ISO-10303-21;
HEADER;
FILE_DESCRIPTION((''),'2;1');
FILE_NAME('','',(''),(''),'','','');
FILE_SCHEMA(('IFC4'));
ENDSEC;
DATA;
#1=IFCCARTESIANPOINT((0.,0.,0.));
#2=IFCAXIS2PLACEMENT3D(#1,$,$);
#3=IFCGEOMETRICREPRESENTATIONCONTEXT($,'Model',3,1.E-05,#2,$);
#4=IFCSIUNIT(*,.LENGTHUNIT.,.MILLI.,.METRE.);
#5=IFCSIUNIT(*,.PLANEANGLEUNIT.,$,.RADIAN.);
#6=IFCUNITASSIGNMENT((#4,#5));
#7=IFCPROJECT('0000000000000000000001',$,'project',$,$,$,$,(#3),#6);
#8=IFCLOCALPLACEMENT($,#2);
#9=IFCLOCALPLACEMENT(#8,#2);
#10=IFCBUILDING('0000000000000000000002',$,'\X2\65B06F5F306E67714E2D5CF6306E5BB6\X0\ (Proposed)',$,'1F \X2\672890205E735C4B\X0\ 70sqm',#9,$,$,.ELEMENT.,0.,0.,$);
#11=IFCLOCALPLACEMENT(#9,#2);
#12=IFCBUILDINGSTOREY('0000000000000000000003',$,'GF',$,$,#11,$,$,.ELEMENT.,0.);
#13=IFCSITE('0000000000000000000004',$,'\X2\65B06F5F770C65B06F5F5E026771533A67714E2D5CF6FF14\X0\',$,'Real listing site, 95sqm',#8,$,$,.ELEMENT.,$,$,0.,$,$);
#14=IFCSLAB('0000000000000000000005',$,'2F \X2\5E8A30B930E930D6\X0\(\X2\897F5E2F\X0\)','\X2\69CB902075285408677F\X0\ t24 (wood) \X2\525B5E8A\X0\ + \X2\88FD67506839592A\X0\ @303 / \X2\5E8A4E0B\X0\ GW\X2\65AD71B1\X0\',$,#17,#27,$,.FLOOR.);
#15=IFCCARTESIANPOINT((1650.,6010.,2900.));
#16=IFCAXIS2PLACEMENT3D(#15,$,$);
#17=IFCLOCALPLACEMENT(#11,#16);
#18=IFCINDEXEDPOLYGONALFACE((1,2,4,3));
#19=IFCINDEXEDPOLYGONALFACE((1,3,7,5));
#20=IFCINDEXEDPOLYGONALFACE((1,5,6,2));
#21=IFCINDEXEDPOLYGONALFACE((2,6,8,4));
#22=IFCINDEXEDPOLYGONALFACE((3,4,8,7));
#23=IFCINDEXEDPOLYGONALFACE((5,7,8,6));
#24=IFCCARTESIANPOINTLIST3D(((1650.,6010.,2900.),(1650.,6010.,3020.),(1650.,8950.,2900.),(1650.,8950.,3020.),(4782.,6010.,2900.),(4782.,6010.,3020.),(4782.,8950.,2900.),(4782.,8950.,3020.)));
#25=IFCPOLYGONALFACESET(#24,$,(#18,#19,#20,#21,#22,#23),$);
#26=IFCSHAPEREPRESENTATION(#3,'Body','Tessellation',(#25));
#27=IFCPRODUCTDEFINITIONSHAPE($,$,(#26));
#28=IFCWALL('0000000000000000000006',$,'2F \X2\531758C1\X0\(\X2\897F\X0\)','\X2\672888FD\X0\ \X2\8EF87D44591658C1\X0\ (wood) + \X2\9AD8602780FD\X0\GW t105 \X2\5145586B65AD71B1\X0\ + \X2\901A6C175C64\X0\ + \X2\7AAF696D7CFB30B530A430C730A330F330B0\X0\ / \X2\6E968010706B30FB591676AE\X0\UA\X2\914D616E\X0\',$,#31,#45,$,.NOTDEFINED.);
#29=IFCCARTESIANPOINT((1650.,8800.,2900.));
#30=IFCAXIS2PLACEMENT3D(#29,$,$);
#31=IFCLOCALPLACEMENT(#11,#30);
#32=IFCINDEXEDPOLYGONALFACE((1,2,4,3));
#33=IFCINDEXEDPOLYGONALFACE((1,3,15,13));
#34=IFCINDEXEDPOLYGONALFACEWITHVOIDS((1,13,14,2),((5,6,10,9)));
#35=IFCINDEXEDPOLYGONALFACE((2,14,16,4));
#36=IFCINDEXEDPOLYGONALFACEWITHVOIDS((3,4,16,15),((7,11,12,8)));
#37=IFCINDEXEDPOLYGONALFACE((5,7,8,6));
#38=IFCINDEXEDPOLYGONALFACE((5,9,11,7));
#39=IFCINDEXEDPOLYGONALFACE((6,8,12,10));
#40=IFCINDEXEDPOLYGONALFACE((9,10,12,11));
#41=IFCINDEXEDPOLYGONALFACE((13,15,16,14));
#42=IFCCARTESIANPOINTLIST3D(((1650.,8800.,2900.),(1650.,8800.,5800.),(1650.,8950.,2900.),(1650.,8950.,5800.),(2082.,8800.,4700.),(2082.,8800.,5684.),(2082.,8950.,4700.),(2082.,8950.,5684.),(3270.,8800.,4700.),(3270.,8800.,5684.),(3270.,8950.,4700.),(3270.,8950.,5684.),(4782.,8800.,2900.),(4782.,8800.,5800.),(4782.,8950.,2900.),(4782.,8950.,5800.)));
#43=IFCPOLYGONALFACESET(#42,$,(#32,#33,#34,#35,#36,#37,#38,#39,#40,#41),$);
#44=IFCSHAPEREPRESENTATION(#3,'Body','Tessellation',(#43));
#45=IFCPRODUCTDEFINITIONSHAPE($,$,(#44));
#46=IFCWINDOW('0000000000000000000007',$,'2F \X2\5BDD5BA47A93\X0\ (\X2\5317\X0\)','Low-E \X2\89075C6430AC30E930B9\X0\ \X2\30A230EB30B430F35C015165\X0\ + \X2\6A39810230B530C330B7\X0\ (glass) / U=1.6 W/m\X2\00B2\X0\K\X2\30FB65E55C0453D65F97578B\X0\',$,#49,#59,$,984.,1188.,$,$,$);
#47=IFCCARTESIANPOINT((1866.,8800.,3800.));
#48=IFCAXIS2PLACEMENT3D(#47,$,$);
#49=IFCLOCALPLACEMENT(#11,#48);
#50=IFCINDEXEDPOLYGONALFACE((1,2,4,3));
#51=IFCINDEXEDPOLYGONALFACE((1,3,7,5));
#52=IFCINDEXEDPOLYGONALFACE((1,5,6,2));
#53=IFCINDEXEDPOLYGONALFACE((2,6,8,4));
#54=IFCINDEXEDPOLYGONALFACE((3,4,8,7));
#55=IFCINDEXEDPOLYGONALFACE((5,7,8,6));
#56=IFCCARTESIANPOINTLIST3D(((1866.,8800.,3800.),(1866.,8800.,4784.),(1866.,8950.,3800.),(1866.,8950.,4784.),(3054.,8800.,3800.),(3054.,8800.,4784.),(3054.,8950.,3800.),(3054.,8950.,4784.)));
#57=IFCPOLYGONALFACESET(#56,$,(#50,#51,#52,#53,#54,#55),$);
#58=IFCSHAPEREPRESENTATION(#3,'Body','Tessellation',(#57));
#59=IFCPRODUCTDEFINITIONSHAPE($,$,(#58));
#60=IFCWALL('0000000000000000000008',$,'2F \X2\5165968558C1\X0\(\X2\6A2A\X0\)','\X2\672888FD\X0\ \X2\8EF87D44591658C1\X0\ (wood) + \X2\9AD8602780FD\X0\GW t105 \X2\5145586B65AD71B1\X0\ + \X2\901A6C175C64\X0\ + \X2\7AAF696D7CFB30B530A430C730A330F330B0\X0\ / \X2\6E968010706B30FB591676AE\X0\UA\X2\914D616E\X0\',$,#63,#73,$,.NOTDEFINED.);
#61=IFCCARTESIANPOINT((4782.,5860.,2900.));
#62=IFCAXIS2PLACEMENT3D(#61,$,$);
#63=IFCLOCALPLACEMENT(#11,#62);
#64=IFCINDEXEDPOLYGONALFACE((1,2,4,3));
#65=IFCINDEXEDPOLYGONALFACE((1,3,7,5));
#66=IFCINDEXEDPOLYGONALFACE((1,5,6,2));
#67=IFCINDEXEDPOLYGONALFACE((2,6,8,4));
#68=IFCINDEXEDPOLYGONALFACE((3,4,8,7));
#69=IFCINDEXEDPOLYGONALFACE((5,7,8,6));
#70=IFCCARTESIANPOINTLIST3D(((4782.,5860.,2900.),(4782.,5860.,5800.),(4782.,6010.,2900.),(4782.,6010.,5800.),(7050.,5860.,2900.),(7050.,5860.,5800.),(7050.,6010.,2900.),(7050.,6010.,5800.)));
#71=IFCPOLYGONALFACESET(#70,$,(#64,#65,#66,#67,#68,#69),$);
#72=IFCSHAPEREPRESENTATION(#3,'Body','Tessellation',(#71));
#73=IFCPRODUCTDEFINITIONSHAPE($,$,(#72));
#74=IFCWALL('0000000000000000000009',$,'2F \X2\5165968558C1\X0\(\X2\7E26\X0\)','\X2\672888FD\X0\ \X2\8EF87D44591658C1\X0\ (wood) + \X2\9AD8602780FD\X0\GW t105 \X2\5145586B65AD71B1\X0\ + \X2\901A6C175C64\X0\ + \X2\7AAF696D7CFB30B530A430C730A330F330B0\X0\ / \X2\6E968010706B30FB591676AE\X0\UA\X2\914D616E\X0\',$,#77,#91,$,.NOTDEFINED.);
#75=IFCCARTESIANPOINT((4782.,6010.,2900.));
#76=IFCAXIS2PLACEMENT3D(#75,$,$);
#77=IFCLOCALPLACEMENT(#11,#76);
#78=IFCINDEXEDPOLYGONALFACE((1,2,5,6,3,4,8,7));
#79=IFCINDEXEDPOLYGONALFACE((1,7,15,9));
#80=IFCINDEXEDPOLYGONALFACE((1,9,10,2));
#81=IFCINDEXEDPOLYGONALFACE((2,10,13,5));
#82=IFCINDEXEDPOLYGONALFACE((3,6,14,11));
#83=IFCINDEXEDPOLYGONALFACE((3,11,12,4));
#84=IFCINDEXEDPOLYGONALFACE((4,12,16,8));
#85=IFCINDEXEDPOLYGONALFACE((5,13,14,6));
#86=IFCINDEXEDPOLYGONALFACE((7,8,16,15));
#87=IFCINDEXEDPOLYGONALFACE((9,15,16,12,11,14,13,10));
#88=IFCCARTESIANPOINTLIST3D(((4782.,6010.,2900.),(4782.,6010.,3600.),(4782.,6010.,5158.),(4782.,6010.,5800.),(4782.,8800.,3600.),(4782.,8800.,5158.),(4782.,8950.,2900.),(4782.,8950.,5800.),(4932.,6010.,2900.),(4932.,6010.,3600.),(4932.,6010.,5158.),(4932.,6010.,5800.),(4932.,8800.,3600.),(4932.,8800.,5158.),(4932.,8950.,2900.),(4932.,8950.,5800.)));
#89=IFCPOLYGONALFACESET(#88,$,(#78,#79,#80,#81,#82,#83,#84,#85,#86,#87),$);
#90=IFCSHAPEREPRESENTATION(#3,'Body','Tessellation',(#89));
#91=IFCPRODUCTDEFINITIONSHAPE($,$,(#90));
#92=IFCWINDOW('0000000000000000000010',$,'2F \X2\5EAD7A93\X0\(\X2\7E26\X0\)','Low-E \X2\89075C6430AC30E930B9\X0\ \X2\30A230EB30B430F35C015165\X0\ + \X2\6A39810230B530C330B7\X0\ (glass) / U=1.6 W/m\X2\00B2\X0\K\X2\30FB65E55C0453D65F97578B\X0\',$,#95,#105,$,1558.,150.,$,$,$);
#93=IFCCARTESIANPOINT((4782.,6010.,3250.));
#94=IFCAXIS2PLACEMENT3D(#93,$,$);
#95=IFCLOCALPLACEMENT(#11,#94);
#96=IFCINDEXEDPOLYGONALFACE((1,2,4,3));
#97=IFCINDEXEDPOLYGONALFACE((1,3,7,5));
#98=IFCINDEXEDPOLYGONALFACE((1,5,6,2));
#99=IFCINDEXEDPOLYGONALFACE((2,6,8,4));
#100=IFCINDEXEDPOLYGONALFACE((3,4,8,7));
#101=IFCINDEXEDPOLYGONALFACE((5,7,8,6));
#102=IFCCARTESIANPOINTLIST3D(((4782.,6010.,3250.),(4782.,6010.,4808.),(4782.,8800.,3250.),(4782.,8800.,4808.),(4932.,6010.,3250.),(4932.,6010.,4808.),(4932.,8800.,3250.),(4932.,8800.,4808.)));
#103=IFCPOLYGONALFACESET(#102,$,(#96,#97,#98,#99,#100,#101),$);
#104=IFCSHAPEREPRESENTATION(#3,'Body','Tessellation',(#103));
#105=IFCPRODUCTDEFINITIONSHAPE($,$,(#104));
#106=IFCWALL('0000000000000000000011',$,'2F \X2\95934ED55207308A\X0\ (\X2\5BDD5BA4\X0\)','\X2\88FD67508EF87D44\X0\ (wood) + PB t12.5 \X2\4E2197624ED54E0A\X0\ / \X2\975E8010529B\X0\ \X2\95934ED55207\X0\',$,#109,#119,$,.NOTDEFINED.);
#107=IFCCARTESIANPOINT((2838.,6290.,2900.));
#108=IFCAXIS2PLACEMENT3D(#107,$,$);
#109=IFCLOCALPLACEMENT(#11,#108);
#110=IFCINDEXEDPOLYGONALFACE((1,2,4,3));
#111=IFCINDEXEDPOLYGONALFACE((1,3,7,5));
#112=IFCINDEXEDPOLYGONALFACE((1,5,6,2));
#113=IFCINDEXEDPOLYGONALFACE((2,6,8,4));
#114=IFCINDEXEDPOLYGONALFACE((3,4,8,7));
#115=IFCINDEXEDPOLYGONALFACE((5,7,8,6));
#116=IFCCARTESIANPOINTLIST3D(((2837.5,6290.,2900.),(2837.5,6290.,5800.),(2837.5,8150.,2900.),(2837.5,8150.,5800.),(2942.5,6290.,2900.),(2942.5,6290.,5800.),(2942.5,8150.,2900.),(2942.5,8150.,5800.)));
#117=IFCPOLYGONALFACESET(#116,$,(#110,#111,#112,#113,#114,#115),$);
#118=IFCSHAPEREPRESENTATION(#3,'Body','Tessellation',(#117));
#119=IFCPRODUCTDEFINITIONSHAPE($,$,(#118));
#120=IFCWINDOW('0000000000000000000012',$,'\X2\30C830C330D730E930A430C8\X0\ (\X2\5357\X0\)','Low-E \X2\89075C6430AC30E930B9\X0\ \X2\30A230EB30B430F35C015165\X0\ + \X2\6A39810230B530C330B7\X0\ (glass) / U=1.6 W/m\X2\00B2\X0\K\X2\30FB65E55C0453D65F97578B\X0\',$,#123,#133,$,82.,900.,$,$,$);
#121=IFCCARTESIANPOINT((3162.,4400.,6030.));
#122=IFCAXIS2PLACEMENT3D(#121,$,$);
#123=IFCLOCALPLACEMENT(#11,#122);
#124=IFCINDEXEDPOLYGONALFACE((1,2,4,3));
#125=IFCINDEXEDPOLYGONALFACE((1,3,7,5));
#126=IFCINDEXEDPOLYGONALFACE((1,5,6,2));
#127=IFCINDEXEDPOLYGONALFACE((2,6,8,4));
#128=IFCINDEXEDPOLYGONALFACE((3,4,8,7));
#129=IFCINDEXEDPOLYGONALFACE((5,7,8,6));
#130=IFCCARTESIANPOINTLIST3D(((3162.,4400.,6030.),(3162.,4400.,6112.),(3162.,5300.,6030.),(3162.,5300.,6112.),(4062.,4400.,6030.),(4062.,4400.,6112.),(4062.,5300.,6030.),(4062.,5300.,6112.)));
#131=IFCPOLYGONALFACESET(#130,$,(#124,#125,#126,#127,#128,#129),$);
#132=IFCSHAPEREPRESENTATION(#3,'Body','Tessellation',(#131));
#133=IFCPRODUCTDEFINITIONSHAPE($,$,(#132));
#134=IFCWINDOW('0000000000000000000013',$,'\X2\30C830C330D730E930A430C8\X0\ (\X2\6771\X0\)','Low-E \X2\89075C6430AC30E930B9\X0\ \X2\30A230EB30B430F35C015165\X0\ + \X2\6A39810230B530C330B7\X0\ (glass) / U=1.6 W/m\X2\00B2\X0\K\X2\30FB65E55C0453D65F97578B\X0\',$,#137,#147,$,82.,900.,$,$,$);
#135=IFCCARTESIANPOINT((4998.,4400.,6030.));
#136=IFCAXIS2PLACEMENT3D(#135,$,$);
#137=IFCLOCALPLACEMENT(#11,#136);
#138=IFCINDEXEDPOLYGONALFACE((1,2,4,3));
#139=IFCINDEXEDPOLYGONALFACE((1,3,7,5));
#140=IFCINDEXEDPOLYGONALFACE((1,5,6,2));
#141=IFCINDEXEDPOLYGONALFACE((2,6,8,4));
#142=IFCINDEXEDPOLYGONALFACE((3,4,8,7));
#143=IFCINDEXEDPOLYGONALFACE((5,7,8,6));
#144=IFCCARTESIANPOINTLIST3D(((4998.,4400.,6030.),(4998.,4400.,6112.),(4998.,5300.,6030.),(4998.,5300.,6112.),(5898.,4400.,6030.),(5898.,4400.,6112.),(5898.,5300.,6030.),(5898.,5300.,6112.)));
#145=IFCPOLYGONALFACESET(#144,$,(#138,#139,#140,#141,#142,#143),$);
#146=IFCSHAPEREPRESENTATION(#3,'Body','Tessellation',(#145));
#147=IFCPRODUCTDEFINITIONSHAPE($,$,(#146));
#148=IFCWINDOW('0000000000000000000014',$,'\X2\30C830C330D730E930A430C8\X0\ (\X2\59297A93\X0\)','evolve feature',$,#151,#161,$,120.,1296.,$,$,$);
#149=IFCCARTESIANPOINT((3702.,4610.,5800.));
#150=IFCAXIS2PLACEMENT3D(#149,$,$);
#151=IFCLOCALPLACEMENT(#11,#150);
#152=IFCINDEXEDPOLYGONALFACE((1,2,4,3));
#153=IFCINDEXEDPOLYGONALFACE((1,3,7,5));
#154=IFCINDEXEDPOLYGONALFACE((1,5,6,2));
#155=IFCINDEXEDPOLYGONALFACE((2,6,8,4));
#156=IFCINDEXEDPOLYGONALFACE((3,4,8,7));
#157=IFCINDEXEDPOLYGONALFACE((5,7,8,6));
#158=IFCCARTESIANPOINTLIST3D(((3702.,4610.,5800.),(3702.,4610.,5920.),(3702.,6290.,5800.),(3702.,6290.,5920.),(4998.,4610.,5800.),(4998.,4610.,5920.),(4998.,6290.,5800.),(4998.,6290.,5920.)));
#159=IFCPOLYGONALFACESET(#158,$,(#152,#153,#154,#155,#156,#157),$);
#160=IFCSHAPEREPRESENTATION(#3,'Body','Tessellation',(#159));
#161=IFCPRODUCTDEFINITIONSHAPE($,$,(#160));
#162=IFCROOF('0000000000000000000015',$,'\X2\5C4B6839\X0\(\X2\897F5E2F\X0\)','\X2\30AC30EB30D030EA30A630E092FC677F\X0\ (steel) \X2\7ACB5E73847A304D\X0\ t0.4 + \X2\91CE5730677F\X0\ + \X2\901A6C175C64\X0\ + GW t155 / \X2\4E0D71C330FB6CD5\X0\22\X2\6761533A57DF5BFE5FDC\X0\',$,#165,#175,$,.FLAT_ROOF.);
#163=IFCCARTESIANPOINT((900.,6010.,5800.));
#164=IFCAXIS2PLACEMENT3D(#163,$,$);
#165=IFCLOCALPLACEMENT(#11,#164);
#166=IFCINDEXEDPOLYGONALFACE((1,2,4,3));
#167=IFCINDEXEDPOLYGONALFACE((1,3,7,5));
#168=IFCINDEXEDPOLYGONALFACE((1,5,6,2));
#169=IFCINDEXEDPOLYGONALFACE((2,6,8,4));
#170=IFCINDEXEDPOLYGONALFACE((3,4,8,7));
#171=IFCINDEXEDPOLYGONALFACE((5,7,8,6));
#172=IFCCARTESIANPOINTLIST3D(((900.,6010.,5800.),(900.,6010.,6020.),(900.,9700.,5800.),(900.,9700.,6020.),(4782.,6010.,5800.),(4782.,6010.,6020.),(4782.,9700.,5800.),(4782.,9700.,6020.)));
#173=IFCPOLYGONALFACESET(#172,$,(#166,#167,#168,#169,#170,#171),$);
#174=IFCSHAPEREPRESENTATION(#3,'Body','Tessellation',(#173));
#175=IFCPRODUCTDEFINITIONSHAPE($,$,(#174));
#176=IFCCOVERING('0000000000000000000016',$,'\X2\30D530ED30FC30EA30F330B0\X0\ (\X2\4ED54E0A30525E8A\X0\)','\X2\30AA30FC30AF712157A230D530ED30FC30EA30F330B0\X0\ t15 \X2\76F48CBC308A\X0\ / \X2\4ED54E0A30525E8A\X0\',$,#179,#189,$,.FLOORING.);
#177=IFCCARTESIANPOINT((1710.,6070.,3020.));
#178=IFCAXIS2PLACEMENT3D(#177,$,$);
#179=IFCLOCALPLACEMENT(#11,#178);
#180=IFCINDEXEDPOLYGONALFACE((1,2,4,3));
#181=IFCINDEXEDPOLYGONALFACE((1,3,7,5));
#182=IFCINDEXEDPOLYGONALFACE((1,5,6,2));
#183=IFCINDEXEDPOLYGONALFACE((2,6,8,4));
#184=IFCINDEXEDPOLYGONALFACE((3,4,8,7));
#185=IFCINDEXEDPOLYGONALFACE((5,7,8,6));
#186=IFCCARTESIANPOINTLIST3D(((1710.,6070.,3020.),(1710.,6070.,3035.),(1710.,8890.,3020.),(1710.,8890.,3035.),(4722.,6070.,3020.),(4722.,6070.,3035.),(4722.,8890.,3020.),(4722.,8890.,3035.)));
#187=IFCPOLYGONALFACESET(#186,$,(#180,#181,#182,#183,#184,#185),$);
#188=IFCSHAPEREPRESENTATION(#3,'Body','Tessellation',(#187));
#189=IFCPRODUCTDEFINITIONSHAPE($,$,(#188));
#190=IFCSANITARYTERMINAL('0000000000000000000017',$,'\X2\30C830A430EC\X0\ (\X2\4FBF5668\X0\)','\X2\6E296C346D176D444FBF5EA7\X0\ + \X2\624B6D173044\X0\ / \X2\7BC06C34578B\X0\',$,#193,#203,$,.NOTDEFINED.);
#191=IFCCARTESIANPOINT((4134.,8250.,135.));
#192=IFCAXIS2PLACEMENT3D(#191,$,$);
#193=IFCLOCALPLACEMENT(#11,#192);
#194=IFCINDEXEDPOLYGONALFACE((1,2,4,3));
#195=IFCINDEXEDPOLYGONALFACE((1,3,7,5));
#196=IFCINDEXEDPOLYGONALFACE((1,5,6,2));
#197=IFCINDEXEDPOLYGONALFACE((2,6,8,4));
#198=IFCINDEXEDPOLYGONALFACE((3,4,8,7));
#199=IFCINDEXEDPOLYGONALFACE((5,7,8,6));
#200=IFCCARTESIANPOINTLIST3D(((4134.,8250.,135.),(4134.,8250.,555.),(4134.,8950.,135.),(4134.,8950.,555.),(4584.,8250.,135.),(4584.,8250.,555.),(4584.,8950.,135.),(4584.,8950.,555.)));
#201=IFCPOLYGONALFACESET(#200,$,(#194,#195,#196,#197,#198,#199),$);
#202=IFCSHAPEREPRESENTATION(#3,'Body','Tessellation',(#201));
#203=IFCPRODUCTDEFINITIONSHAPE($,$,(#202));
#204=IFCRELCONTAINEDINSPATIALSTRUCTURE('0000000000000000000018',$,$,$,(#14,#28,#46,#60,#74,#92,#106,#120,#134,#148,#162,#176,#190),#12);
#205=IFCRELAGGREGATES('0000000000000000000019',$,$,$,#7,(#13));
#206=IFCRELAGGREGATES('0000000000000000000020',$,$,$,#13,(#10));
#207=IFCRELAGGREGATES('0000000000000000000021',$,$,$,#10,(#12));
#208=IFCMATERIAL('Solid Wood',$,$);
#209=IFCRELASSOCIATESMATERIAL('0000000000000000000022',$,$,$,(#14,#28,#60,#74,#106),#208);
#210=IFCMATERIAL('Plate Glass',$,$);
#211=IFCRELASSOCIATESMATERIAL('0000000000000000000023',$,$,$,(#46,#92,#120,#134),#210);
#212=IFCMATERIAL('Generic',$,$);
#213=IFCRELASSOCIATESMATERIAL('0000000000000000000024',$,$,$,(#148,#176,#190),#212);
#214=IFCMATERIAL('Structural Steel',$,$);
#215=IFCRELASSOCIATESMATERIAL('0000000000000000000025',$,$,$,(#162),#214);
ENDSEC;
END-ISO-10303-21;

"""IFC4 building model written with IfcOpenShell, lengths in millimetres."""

from ifc_helpers import new_model, si_unit, frame, frame_2d, origin, place, context, project, spatial, rectangle, extrude, material, element, fill, save


model = new_model("IFC4")

# Units and contexts
model_context = context("Model", 3, precision=1e-05, world=origin())
ifc_project = project(units=[si_unit("LENGTHUNIT", "METRE", prefix="MILLI"), si_unit("PLANEANGLEUNIT", "RADIAN")], contexts=[model_context])

# Site, building, storey
site_placement = place(None, origin())
site = spatial("IfcSite", under=ifc_project, at=site_placement, Name="新潟県新潟市東区東中島４", ObjectType="Real listing site, 95sqm", CompositionType="ELEMENT", RefElevation=0.0)
building_placement = place(site_placement, origin())
building = spatial("IfcBuilding", under=site, at=building_placement, Name="新潟の東中島の家 (Proposed)", ObjectType="1F 木造平屋 70sqm", CompositionType="ELEMENT", ElevationOfRefHeight=0.0, ElevationOfTerrain=0.0)
storey_placement = place(building_placement, origin())
storey = spatial("IfcBuildingStorey", under=building, at=storey_placement, Name="GF", CompositionType="ELEMENT", Elevation=0.0)

# Slab
ifc_material_1 = material(Name="Solid Wood")
slab_placement = place(storey_placement, frame((1650.0, 6010.0, 2900.0)))
element("IfcSlab", 1, at=slab_placement, inside=storey, material=ifc_material_1, Name="2F 床スラブ(西帯)", Description="構造用合板 t24 (wood) 剛床 + 製材根太 @303 / 床下 GW断熱", PredefinedType="FLOOR", context=model_context, shape_type="SweptSolid", body=[
    extrude(rectangle(XDim=3132.0, YDim=2940.0, at=frame_2d((1566.0, 1470.0))), frame((1650.0, 6010.0, 2900.0)), (0.0, 0.0, 1.0), 120.0),
])

# Wall, opening, window
wall_1_placement = place(storey_placement, frame((1650.0, 8800.0, 2900.0)))
wall_1 = element("IfcWall", 2, at=wall_1_placement, inside=storey, material=ifc_material_1, Name="2F 北壁(西)", Description="木製 軸組外壁 (wood) + 高性能GW t105 充填断熱 + 通気層 + 窯業系サイディング / 準耐火・外皮UA配慮", PredefinedType="NOTDEFINED", context=model_context, shape_type="SweptSolid", body=[
    extrude(rectangle(XDim=3132.0, YDim=150.0, at=frame_2d((1566.0, 75.0))), frame((1650.0, 8800.0, 2900.0)), (0.0, 0.0, 1.0), 2900.0),
])
opening_1_placement = place(storey_placement, frame((1866.0, 8800.0, 3800.0)))
opening_1 = element("IfcOpeningElement", 3, at=opening_1_placement, cuts=wall_1, PredefinedType="NOTDEFINED", context=model_context, shape_type="SweptSolid", body=[
    extrude(rectangle(XDim=1188.0, YDim=150.0, at=frame_2d((594.0, 75.0))), frame((1866.0, 8800.0, 3800.0)), (0.0, 0.0, 1.0), 984.0),
])
ifc_material_2 = material(Name="Plate Glass")
window_1_placement = place(storey_placement, frame((1866.0, 8800.0, 3800.0)))
window_1 = element("IfcWindow", 4, at=window_1_placement, inside=storey, material=ifc_material_2, Name="2F 寝室窓 (北)", Description="Low-E 複層ガラス アルゴン封入 + 樹脂サッシ (glass) / U=1.6 W/m²K・日射取得型", OverallHeight=984.0, OverallWidth=1188.0, context=model_context, shape_type="SweptSolid", body=[
    extrude(rectangle(XDim=1188.0, YDim=150.0, at=frame_2d((594.0, 75.0))), frame((1866.0, 8800.0, 3800.0)), (0.0, 0.0, 1.0), 984.0),
])
fill(opening_1, window_1)

# Wall
wall_2_placement = place(storey_placement, frame((4782.0, 5860.0, 2900.0)))
element("IfcWall", 5, at=wall_2_placement, inside=storey, material=ifc_material_1, Name="2F 入隅壁(横)", Description="木製 軸組外壁 (wood) + 高性能GW t105 充填断熱 + 通気層 + 窯業系サイディング / 準耐火・外皮UA配慮", PredefinedType="NOTDEFINED", context=model_context, shape_type="SweptSolid", body=[
    extrude(rectangle(XDim=2268.0, YDim=150.0, at=frame_2d((1134.0, 75.0))), frame((4782.0, 5860.0, 2900.0)), (0.0, 0.0, 1.0), 2900.0),
])

# Wall, opening, window
wall_3_placement = place(storey_placement, frame((4782.0, 6010.0, 2900.0)))
wall_3 = element("IfcWall", 6, at=wall_3_placement, inside=storey, material=ifc_material_1, Name="2F 入隅壁(縦)", Description="木製 軸組外壁 (wood) + 高性能GW t105 充填断熱 + 通気層 + 窯業系サイディング / 準耐火・外皮UA配慮", PredefinedType="NOTDEFINED", context=model_context, shape_type="SweptSolid", body=[
    extrude(rectangle(XDim=150.0, YDim=2940.0, at=frame_2d((75.0, 1470.0))), frame((4782.0, 6010.0, 2900.0)), (0.0, 0.0, 1.0), 2900.0),
])
opening_2_placement = place(storey_placement, frame((4782.0, 6010.0, 3250.0)))
opening_2 = element("IfcOpeningElement", 7, at=opening_2_placement, cuts=wall_3, PredefinedType="NOTDEFINED", context=model_context, shape_type="SweptSolid", body=[
    extrude(rectangle(XDim=150.0, YDim=2790.0, at=frame_2d((75.0, 1395.0))), frame((4782.0, 6010.0, 3250.0)), (0.0, 0.0, 1.0), 1558.0),
])
window_2_placement = place(storey_placement, frame((4782.0, 6010.0, 3250.0)))
window_2 = element("IfcWindow", 8, at=window_2_placement, inside=storey, material=ifc_material_2, Name="2F 庭窓(縦)", Description="Low-E 複層ガラス アルゴン封入 + 樹脂サッシ (glass) / U=1.6 W/m²K・日射取得型", OverallHeight=1558.0, OverallWidth=150.0, context=model_context, shape_type="SweptSolid", body=[
    extrude(rectangle(XDim=150.0, YDim=2790.0, at=frame_2d((75.0, 1395.0))), frame((4782.0, 6010.0, 3250.0)), (0.0, 0.0, 1.0), 1558.0),
])
fill(opening_2, window_2)

# Wall
wall_4_placement = place(storey_placement, frame((2838.0, 6290.0, 2900.0)))
element("IfcWall", 9, at=wall_4_placement, inside=storey, material=ifc_material_1, Name="2F 間仕切り (寝室)", Description="製材軸組 (wood) + PB t12.5 両面仕上 / 非耐力 間仕切", PredefinedType="NOTDEFINED", context=model_context, shape_type="SweptSolid", body=[
    extrude(rectangle(XDim=105.0, YDim=1860.0, at=frame_2d((52.0, 930.0))), frame((2838.0, 6290.0, 2900.0)), (0.0, 0.0, 1.0), 2900.0),
])

# Windows
window_3_placement = place(storey_placement, frame((3162.0, 4400.0, 6030.0)))
element("IfcWindow", 10, at=window_3_placement, inside=storey, material=ifc_material_2, Name="トップライト (南)", Description="Low-E 複層ガラス アルゴン封入 + 樹脂サッシ (glass) / U=1.6 W/m²K・日射取得型", OverallHeight=82.0, OverallWidth=900.0, context=model_context, shape_type="SweptSolid", body=[
    extrude(rectangle(XDim=900.0, YDim=900.0, at=frame_2d((450.0, 450.0))), frame((3162.0, 4400.0, 6030.0)), (0.0, 0.0, 1.0), 82.0),
])
window_4_placement = place(storey_placement, frame((4998.0, 4400.0, 6030.0)))
element("IfcWindow", 11, at=window_4_placement, inside=storey, material=ifc_material_2, Name="トップライト (東)", Description="Low-E 複層ガラス アルゴン封入 + 樹脂サッシ (glass) / U=1.6 W/m²K・日射取得型", OverallHeight=82.0, OverallWidth=900.0, context=model_context, shape_type="SweptSolid", body=[
    extrude(rectangle(XDim=900.0, YDim=900.0, at=frame_2d((450.0, 450.0))), frame((4998.0, 4400.0, 6030.0)), (0.0, 0.0, 1.0), 82.0),
])
ifc_material_3 = material(Name="Generic")
window_5_placement = place(storey_placement, frame((3702.0, 4610.0, 5800.0)))
element("IfcWindow", 12, at=window_5_placement, inside=storey, material=ifc_material_3, Name="トップライト (天窓)", Description="evolve feature", OverallHeight=120.0, OverallWidth=1296.0, context=model_context, shape_type="SweptSolid", body=[
    extrude(rectangle(XDim=1296.0, YDim=1680.0, at=frame_2d((648.0, 840.0))), frame((3702.0, 4610.0, 5800.0)), (0.0, 0.0, 1.0), 120.0),
])

# Roof
ifc_material_4 = material(Name="Structural Steel")
for number, where, name in (
    (13, (900.0, 6010.0, 5800.0), "屋根(西帯)"),
):
    element("IfcRoof", number, at=place(storey_placement, frame(where)), inside=storey, material=ifc_material_4, Name=name, Description="ガルバリウム鋼板 (steel) 立平葺き t0.4 + 野地板 + 通気層 + GW t155 / 不燃・法22条区域対応", PredefinedType="FLAT_ROOF", context=model_context, shape_type="SweptSolid", body=[
        extrude(rectangle(XDim=3882.0, YDim=3690.0, at=frame_2d((1941.0, 1845.0))), frame((900.0, 6010.0, 5800.0)), (0.0, 0.0, 1.0), 220.0),
    ])

# Covering
covering_placement = place(storey_placement, frame((1710.0, 6070.0, 3020.0)))
element("IfcCovering", 14, at=covering_placement, inside=storey, material=ifc_material_3, Name="フローリング (仕上げ床)", Description="オーク無垢フローリング t15 直貼り / 仕上げ床", PredefinedType="FLOORING", context=model_context, shape_type="SweptSolid", body=[
    extrude(rectangle(XDim=3012.0, YDim=2820.0, at=frame_2d((1506.0, 1410.0))), frame((1710.0, 6070.0, 3020.0)), (0.0, 0.0, 1.0), 15.0),
])

# Sanitary terminal
sanitary_terminal_placement = place(storey_placement, frame((4134.0, 8250.0, 135.0)))
element("IfcSanitaryTerminal", 15, at=sanitary_terminal_placement, inside=storey, material=ifc_material_3, Name="トイレ (便器)", Description="温水洗浄便座 + 手洗い / 節水型", PredefinedType="NOTDEFINED", context=model_context, shape_type="SweptSolid", body=[
    extrude(rectangle(XDim=450.0, YDim=700.0, at=frame_2d((225.0, 350.0))), frame((4134.0, 8250.0, 135.0)), (0.0, 0.0, 1.0), 420.0),
])

save(model, "model.ifc")
